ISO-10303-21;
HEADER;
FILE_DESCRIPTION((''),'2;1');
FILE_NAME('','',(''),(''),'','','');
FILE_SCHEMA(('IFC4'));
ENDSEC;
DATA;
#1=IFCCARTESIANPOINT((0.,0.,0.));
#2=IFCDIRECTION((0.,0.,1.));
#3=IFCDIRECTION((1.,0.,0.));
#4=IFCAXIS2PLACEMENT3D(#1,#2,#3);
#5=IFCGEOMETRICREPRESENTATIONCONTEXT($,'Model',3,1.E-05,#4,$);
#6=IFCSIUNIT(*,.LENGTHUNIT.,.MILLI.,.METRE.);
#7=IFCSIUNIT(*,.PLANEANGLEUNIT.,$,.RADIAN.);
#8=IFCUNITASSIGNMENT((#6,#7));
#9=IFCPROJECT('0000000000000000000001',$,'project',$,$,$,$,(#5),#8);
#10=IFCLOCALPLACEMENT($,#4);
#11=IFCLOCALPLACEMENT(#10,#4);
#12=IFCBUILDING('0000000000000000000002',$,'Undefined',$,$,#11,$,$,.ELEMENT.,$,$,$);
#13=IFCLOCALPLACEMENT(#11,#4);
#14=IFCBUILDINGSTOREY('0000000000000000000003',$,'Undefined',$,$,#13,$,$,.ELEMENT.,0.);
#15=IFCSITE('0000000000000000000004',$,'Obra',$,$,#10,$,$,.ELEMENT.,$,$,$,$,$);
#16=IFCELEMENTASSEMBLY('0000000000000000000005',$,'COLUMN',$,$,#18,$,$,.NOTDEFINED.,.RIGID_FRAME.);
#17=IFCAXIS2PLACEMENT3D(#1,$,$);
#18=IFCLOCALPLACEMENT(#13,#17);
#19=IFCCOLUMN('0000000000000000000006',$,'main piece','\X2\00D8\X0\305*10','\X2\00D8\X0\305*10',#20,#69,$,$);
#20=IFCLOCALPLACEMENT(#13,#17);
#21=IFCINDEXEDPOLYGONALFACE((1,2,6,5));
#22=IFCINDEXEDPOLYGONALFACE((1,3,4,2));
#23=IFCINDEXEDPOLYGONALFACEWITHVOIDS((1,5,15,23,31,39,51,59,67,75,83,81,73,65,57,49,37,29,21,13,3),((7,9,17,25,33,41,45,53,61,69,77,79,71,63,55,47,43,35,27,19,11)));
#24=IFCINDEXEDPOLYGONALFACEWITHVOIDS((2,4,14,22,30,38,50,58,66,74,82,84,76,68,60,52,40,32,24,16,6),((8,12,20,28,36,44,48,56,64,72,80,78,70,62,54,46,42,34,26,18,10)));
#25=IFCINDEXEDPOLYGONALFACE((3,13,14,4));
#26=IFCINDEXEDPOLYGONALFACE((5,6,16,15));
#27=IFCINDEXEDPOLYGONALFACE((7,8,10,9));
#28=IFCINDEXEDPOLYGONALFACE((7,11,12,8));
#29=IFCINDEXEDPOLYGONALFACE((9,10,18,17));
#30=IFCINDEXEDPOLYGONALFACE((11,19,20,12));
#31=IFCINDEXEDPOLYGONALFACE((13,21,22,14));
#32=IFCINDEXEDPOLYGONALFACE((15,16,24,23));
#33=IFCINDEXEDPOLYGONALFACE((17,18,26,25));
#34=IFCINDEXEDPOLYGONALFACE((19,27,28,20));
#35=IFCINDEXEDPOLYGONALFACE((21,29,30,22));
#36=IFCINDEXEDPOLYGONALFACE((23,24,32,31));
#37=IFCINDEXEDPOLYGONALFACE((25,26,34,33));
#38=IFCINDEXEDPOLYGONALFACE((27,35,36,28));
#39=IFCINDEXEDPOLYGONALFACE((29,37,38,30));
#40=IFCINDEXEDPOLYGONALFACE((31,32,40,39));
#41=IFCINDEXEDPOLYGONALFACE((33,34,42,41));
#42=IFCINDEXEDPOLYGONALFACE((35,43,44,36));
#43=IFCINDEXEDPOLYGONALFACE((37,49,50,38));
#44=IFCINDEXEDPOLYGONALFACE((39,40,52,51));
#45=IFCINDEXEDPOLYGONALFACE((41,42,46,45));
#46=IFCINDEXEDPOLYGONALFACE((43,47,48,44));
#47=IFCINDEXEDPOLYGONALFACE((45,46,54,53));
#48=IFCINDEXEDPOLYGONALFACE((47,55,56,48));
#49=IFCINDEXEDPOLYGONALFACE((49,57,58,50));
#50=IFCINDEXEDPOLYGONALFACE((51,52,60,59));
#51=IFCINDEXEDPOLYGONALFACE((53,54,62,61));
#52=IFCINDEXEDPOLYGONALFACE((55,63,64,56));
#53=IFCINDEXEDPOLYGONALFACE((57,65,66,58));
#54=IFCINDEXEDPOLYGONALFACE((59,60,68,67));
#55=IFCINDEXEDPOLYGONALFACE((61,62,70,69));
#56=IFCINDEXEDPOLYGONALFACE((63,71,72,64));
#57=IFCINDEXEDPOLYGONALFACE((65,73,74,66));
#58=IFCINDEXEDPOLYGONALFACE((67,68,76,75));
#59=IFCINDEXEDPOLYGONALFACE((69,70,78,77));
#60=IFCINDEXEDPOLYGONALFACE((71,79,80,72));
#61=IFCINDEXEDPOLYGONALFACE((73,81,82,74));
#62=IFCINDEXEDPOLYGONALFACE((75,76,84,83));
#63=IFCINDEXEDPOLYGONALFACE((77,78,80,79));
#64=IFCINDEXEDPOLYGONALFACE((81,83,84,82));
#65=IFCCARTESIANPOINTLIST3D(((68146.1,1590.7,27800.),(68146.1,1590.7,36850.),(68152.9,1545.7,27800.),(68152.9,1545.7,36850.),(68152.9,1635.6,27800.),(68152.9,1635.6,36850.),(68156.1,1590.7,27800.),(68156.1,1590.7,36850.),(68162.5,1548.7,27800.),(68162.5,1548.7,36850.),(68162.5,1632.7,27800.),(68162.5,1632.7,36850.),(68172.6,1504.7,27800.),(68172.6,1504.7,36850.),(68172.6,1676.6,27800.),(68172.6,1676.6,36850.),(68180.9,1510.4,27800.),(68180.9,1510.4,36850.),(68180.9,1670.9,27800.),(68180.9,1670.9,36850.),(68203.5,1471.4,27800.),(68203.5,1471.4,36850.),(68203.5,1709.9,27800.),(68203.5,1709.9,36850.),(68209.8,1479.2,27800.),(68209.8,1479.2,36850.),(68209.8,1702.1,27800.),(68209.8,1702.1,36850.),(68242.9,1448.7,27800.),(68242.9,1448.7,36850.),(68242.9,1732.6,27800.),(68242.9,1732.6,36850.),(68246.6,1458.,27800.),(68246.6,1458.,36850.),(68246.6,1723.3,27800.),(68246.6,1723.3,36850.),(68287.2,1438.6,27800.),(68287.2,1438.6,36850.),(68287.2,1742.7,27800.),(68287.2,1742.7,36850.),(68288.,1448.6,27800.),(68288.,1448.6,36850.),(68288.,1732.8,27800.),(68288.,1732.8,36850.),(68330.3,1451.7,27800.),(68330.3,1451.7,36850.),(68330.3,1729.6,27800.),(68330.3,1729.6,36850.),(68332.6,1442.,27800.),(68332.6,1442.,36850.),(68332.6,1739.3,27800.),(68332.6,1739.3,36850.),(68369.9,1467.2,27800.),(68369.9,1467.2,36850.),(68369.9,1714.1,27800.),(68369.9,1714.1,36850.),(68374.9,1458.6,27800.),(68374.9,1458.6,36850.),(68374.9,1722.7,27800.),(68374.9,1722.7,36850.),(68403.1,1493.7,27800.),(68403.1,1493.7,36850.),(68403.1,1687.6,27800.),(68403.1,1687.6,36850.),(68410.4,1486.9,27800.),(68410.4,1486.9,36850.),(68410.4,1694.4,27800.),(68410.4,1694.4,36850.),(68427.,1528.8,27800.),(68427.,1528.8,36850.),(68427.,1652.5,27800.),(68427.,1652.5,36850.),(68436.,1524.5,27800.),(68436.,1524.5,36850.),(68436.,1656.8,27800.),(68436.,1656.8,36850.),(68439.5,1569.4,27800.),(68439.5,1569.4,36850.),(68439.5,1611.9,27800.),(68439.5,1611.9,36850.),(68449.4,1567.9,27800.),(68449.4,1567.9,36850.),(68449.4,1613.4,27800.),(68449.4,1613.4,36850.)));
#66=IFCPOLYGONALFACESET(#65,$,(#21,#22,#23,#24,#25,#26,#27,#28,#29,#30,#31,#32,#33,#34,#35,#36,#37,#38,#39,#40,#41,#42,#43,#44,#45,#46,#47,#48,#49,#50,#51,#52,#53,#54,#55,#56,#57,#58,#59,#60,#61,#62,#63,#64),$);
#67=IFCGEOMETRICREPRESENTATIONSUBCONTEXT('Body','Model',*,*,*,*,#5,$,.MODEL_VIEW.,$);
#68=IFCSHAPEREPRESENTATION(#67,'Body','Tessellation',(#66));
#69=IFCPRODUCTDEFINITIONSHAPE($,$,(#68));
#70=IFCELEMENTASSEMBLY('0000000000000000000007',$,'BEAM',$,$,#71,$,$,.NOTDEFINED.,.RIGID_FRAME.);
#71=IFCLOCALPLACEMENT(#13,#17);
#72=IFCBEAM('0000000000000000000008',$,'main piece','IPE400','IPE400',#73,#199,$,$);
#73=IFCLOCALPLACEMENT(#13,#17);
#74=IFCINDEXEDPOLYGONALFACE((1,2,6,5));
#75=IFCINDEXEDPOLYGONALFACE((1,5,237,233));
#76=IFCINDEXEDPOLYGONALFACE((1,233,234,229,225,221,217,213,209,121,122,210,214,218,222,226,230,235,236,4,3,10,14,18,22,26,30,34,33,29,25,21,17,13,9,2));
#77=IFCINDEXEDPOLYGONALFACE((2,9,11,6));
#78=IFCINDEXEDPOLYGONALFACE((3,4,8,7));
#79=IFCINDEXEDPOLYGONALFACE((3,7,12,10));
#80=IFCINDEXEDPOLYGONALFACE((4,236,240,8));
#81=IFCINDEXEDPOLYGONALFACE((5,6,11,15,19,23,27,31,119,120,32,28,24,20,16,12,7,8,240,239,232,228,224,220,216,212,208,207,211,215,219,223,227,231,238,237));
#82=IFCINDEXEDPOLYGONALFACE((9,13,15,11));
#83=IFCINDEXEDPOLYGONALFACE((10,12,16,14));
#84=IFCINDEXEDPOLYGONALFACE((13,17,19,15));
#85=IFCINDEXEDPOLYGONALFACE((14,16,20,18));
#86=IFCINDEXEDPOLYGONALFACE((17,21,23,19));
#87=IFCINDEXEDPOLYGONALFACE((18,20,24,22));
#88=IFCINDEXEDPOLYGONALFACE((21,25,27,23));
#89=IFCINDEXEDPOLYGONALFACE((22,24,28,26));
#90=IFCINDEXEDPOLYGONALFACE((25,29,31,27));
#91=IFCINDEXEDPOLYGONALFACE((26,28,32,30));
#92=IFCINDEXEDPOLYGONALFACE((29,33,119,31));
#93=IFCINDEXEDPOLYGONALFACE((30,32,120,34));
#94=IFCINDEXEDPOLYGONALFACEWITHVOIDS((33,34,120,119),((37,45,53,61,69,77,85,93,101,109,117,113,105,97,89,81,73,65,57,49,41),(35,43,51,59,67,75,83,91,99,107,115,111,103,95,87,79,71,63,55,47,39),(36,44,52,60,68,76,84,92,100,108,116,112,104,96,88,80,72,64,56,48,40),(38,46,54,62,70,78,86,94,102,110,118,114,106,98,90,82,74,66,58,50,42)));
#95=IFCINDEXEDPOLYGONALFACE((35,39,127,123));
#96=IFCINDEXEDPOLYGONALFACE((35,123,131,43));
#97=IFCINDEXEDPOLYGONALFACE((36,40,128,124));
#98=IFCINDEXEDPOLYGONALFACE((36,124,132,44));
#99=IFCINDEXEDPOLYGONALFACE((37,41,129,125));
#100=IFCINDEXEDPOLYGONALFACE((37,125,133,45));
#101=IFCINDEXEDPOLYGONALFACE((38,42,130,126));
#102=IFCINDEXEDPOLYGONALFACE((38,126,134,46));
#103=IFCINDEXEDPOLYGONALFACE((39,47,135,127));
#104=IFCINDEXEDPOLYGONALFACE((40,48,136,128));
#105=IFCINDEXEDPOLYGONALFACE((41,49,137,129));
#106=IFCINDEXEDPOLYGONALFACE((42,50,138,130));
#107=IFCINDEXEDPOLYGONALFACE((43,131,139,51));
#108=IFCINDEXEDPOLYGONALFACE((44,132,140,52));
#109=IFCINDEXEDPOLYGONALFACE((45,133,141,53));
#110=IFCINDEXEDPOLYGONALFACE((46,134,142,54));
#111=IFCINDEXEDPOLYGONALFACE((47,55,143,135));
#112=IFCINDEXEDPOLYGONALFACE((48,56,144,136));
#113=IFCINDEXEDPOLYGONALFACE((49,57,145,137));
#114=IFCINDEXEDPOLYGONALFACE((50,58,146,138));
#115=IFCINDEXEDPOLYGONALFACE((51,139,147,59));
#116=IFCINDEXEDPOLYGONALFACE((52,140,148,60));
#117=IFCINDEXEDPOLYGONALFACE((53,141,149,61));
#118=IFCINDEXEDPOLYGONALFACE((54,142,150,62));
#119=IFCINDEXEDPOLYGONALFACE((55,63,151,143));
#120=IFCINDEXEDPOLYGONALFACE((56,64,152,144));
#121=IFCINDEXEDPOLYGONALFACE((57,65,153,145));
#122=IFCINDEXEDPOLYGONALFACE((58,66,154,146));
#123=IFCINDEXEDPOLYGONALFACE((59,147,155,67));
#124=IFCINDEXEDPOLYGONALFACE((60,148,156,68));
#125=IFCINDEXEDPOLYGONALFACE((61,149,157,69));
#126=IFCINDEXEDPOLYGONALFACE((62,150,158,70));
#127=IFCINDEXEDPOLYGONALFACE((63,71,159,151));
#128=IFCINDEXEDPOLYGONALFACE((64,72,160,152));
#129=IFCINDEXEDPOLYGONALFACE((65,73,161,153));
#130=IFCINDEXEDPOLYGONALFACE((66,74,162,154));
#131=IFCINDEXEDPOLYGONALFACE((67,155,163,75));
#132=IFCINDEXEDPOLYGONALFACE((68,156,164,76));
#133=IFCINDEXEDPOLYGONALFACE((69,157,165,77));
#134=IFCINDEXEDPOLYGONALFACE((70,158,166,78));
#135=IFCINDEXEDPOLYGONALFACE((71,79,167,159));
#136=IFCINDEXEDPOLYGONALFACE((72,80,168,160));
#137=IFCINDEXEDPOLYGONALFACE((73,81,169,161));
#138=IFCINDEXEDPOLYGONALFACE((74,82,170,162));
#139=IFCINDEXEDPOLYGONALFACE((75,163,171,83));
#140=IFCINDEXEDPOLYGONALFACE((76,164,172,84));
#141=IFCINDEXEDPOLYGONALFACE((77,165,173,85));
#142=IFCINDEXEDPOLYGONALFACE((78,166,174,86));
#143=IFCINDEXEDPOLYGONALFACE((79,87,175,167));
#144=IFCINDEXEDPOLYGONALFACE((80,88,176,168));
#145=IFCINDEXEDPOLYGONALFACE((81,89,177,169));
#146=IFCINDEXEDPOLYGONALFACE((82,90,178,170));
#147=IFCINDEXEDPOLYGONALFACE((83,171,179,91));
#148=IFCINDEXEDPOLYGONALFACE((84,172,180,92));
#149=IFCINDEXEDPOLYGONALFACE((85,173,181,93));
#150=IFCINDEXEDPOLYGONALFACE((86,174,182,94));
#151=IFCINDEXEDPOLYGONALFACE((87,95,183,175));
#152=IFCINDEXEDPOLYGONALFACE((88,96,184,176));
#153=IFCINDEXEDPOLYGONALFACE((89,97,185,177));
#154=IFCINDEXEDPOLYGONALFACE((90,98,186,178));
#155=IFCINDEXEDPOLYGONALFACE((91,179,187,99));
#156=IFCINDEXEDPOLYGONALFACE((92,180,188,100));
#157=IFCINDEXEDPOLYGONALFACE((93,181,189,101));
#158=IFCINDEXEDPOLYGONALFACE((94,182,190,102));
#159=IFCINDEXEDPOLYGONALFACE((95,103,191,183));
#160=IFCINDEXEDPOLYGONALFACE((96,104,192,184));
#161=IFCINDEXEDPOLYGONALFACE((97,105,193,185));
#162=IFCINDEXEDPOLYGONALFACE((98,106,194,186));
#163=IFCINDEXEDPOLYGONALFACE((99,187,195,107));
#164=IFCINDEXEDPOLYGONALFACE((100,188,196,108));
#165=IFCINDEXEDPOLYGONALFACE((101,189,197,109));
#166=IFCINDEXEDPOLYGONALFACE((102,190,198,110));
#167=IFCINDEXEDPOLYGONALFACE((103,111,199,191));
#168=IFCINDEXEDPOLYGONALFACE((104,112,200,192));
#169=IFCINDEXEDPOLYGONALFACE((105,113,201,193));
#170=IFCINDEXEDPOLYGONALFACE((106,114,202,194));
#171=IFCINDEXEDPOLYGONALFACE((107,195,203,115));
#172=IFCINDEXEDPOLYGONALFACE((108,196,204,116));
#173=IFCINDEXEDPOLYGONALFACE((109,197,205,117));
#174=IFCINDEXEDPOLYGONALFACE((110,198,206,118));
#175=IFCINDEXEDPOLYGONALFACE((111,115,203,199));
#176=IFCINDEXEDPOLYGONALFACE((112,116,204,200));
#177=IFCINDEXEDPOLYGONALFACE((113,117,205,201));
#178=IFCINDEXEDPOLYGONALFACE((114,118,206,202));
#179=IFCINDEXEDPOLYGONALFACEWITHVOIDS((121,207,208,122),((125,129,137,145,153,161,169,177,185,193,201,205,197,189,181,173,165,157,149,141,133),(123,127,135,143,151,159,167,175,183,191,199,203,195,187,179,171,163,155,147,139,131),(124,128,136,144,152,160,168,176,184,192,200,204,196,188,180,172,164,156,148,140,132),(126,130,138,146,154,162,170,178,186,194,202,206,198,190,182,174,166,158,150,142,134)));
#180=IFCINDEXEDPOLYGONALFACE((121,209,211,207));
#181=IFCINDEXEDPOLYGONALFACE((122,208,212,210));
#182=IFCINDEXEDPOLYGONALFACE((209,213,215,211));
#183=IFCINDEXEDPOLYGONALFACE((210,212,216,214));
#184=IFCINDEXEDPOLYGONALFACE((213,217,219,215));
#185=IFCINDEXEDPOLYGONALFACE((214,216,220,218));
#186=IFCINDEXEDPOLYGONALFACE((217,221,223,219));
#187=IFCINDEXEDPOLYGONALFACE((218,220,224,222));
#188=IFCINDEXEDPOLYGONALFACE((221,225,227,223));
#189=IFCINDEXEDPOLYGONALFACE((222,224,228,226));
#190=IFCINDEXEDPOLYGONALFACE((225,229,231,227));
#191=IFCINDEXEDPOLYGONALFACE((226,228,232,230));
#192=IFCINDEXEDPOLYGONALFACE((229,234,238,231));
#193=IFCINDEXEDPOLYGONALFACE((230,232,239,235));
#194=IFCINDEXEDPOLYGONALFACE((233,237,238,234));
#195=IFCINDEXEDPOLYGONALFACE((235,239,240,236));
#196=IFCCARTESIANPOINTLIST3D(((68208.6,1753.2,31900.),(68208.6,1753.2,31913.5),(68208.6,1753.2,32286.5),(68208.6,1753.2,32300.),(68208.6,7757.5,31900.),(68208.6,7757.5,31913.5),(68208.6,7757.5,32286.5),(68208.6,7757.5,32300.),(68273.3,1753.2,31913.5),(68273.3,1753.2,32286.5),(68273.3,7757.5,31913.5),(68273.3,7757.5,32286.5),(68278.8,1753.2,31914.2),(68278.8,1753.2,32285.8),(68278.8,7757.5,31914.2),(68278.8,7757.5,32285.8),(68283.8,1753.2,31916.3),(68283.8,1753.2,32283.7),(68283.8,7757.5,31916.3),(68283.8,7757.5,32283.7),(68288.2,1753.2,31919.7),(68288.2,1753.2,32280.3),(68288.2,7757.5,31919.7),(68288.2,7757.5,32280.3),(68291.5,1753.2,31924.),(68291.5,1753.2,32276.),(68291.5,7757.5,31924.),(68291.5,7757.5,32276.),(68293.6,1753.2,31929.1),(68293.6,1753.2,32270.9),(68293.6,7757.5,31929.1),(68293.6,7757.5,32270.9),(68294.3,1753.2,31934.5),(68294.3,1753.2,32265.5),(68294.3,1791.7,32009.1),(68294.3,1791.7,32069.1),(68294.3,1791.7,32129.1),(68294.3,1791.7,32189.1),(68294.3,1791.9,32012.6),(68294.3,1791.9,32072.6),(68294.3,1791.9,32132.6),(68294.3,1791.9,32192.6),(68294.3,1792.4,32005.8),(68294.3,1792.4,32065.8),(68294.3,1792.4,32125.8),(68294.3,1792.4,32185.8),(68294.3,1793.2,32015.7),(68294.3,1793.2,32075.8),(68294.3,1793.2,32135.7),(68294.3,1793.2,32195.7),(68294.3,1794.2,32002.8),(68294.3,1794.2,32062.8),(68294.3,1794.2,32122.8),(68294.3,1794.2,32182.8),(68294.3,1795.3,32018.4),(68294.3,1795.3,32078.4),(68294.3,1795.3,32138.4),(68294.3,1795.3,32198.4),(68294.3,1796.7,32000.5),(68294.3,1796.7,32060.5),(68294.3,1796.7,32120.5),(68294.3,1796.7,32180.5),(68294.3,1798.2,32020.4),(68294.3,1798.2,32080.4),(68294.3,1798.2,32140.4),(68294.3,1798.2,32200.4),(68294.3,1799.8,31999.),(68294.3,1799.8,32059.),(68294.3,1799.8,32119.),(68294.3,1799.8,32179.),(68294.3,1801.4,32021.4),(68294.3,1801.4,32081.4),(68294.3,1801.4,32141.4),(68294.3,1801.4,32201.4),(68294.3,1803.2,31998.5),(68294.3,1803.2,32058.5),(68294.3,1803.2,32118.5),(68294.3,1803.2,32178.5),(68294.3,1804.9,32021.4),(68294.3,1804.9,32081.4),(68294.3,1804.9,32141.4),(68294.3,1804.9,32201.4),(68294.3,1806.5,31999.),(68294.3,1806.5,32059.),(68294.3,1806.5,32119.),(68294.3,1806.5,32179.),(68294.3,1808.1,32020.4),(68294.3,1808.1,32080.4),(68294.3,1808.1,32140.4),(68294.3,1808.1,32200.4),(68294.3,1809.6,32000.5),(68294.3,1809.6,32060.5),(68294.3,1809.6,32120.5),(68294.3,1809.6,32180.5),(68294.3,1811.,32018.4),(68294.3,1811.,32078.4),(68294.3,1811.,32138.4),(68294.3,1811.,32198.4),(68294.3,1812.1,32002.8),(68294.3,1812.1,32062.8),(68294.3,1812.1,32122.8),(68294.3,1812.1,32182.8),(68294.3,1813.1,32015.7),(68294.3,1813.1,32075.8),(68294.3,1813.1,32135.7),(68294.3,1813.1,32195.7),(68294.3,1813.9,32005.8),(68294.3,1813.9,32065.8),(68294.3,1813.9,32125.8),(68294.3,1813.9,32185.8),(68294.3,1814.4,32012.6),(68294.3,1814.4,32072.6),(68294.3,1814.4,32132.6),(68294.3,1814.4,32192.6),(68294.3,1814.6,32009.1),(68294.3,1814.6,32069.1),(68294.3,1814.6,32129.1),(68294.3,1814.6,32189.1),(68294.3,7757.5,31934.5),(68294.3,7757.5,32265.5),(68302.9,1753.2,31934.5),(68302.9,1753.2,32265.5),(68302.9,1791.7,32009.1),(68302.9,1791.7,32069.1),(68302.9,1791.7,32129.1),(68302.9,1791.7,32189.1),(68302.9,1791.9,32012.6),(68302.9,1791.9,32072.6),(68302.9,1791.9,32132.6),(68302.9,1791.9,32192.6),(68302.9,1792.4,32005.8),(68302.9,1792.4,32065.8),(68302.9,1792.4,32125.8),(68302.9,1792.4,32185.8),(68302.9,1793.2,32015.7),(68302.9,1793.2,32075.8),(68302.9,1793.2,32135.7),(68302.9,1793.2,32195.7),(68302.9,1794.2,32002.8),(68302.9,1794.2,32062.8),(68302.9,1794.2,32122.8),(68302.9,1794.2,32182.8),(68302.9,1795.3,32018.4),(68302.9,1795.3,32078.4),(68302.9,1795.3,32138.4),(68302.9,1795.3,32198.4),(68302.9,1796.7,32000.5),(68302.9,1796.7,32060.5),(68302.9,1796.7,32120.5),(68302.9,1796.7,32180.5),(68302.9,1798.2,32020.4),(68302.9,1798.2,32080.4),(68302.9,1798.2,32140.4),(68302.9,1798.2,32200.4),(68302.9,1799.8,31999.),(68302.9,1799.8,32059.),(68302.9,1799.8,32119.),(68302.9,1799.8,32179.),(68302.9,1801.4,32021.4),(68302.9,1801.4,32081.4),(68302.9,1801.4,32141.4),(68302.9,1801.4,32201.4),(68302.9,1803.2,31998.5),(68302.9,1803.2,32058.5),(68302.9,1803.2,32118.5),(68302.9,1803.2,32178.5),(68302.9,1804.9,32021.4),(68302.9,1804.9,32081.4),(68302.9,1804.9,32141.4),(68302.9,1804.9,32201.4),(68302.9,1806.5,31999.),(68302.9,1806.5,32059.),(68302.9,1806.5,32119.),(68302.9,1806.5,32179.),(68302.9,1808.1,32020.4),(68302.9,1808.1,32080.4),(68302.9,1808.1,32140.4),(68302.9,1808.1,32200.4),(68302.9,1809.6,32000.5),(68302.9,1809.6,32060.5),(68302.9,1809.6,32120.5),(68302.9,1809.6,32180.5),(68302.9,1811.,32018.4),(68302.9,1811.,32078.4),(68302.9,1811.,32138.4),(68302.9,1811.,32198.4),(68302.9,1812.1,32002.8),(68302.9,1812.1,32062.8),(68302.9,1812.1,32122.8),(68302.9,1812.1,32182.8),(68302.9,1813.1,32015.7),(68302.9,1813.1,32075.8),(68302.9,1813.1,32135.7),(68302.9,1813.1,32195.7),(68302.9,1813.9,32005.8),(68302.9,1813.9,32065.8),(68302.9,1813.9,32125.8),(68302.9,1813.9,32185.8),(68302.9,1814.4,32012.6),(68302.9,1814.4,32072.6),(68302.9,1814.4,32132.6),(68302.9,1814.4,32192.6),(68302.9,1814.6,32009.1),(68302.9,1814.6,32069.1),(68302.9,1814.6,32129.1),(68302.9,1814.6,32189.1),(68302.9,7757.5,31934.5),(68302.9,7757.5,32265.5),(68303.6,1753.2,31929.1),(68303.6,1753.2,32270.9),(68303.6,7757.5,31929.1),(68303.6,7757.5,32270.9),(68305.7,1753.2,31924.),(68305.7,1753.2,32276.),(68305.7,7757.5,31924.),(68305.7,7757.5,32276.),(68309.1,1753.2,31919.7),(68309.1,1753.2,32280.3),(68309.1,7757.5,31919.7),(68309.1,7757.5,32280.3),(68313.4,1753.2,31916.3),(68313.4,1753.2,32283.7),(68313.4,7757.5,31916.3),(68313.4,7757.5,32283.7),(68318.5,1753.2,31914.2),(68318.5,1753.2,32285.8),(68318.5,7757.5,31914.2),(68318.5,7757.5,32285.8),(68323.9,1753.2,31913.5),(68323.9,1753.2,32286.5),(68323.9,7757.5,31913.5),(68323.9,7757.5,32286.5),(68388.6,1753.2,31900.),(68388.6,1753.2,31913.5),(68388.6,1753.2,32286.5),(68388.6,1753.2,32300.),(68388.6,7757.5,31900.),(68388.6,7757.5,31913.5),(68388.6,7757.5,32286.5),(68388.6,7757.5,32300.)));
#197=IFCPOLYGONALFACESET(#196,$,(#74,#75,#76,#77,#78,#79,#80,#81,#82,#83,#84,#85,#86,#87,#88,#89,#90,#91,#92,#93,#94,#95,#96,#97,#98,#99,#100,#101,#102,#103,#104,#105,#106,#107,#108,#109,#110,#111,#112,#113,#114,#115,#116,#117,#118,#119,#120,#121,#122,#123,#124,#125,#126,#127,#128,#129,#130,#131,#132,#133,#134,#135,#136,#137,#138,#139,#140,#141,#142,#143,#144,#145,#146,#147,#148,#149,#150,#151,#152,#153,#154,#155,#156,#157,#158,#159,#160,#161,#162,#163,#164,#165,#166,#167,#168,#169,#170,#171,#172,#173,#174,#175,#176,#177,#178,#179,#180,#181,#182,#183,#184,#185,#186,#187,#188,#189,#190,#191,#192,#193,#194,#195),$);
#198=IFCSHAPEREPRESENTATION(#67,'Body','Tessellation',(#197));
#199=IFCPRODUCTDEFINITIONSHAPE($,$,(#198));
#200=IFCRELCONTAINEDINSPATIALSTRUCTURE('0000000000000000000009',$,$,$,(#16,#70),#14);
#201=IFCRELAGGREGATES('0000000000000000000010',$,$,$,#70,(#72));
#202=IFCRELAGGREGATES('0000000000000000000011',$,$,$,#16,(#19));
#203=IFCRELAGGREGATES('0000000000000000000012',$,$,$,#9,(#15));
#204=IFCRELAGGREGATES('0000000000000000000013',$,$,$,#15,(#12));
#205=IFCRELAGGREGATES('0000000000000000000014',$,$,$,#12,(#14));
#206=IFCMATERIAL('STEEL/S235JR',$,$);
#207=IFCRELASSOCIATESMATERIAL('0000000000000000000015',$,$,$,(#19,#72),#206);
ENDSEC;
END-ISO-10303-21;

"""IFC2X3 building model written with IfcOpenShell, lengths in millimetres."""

from ifc_helpers import new_model, si_unit, frame, origin_with_axes, origin_2d_with_axis, place, context, subcontext, project, spatial, circle, hollow_circle, i_section, extrude, clip, halfspace, source, transform, mapped, material, element, aggregate, save


model = new_model("IFC2X3")

# Units and contexts
model_context = context("Model", 3, precision=1e-05, world=origin_with_axes())
body_context = subcontext(model_context, "Body", "Model", "MODEL_VIEW")
ifc_project = project(units=[si_unit("LENGTHUNIT", "METRE", prefix="MILLI"), si_unit("PLANEANGLEUNIT", "RADIAN")], contexts=[model_context])

# Site, building, storey
site_placement = place(None, origin_with_axes())
site = spatial("IfcSite", under=ifc_project, at=site_placement, Name="Obra", CompositionType="ELEMENT")
building_placement = place(site_placement, origin_with_axes())
building = spatial("IfcBuilding", under=site, at=building_placement, Name="Undefined", CompositionType="ELEMENT")
storey_placement = place(building_placement, origin_with_axes())
storey = spatial("IfcBuildingStorey", under=building, at=storey_placement, Name="Undefined", CompositionType="ELEMENT", Elevation=0.0)

# Element assembly, column
assembly_1_placement = place(storey_placement, origin_with_axes())
assembly_1 = element("IfcElementAssembly", 1, at=assembly_1_placement, inside=storey, Name="COLUMN", AssemblyPlace="NOTDEFINED", PredefinedType="RIGID_FRAME")
ifc_material_1 = material(Name="STEEL/S235JR")
column_placement = place(assembly_1_placement, frame((68298.6, 1590.7, 27800.0), z_axis=(0.0, 0.0, 1.0), x_axis=(0.0, 1.0, 0.0)))
column = element("IfcColumn", 2, at=column_placement, material=ifc_material_1, Name="main piece", Description="Ø305*10", ObjectType="Ø305*10", context=body_context, shape_type="SweptSolid", body=[
    extrude(hollow_circle(Radius=152.5, WallThickness=10.0, at=origin_2d_with_axis()), frame((0.0, 0.0, 9050.0), z_axis=(0.0, 0.0, -1.0), x_axis=(0.0, 1.0, 0.0)), (0.0, 0.0, 1.0), 9050.0),
])

# Element assembly, beam, opening
assembly_2_placement = place(storey_placement, origin_with_axes())
assembly_2 = element("IfcElementAssembly", 3, at=assembly_2_placement, inside=storey, Name="BEAM", AssemblyPlace="NOTDEFINED", PredefinedType="RIGID_FRAME")
beam_1_placement = place(assembly_2_placement, frame((68298.6, 1763.8, 32100.0), z_axis=(0.0, 0.0, 1.0), x_axis=(0.0, 1.0, 0.0)))
beam_1 = element("IfcBeam", 4, at=beam_1_placement, material=ifc_material_1, Name="main piece", Description="IPE400", ObjectType="IPE400", context=body_context, shape_type="Clipping", body=[
    clip(extrude(i_section(OverallWidth=180.0, OverallDepth=400.0, WebThickness=8.6, FlangeThickness=13.5, FilletRadius=21.0, at=origin_2d_with_axis()), frame((5993.7, 0.0, 0.0), z_axis=(-1.0, 0.0, 0.0), x_axis=(0.0, -1.0, 0.0)), (0.0, 0.0, 1.0), 6004.3), halfspace(frame((-10.7, 0.0, -300.0), z_axis=(1.0, 0.0, 0.0), x_axis=(0.0, -1.0, 0.0)), True)),
])
shared_shape_1 = source(origin_with_axes(), body_context, "Body", "SweptSolid", [
    extrude(circle(Radius=11.5, at=origin_2d_with_axis()), frame((0.0, -4.4, 0.0), z_axis=(0.0, 1.0, 0.0), x_axis=(1.0, 0.0, 0.0)), (0.0, 0.0, 1.0), 8.8),
])
opening_1_placement = place(assembly_2_placement, frame((68298.6, 1753.2, 32300.0), z_axis=(0.0, 1.0, 0.0), x_axis=(0.0, 0.0, -1.0)))
element("IfcOpeningElement", 5, at=opening_1_placement, cuts=beam_1, ObjectType="Opening", context=body_context, shape_type="MappedRepresentation", body=[
    mapped(shared_shape_1, transform((110.0, 0.0, 50.0))),
    mapped(shared_shape_1, transform((170.0, 0.0, 50.0))),
    mapped(shared_shape_1, transform((230.0, 0.0, 50.0))),
    mapped(shared_shape_1, transform((290.0, 0.0, 50.0))),
])

aggregate(assembly_2, [beam_1])

aggregate(assembly_1, [column])

save(model, "model.ifc")
